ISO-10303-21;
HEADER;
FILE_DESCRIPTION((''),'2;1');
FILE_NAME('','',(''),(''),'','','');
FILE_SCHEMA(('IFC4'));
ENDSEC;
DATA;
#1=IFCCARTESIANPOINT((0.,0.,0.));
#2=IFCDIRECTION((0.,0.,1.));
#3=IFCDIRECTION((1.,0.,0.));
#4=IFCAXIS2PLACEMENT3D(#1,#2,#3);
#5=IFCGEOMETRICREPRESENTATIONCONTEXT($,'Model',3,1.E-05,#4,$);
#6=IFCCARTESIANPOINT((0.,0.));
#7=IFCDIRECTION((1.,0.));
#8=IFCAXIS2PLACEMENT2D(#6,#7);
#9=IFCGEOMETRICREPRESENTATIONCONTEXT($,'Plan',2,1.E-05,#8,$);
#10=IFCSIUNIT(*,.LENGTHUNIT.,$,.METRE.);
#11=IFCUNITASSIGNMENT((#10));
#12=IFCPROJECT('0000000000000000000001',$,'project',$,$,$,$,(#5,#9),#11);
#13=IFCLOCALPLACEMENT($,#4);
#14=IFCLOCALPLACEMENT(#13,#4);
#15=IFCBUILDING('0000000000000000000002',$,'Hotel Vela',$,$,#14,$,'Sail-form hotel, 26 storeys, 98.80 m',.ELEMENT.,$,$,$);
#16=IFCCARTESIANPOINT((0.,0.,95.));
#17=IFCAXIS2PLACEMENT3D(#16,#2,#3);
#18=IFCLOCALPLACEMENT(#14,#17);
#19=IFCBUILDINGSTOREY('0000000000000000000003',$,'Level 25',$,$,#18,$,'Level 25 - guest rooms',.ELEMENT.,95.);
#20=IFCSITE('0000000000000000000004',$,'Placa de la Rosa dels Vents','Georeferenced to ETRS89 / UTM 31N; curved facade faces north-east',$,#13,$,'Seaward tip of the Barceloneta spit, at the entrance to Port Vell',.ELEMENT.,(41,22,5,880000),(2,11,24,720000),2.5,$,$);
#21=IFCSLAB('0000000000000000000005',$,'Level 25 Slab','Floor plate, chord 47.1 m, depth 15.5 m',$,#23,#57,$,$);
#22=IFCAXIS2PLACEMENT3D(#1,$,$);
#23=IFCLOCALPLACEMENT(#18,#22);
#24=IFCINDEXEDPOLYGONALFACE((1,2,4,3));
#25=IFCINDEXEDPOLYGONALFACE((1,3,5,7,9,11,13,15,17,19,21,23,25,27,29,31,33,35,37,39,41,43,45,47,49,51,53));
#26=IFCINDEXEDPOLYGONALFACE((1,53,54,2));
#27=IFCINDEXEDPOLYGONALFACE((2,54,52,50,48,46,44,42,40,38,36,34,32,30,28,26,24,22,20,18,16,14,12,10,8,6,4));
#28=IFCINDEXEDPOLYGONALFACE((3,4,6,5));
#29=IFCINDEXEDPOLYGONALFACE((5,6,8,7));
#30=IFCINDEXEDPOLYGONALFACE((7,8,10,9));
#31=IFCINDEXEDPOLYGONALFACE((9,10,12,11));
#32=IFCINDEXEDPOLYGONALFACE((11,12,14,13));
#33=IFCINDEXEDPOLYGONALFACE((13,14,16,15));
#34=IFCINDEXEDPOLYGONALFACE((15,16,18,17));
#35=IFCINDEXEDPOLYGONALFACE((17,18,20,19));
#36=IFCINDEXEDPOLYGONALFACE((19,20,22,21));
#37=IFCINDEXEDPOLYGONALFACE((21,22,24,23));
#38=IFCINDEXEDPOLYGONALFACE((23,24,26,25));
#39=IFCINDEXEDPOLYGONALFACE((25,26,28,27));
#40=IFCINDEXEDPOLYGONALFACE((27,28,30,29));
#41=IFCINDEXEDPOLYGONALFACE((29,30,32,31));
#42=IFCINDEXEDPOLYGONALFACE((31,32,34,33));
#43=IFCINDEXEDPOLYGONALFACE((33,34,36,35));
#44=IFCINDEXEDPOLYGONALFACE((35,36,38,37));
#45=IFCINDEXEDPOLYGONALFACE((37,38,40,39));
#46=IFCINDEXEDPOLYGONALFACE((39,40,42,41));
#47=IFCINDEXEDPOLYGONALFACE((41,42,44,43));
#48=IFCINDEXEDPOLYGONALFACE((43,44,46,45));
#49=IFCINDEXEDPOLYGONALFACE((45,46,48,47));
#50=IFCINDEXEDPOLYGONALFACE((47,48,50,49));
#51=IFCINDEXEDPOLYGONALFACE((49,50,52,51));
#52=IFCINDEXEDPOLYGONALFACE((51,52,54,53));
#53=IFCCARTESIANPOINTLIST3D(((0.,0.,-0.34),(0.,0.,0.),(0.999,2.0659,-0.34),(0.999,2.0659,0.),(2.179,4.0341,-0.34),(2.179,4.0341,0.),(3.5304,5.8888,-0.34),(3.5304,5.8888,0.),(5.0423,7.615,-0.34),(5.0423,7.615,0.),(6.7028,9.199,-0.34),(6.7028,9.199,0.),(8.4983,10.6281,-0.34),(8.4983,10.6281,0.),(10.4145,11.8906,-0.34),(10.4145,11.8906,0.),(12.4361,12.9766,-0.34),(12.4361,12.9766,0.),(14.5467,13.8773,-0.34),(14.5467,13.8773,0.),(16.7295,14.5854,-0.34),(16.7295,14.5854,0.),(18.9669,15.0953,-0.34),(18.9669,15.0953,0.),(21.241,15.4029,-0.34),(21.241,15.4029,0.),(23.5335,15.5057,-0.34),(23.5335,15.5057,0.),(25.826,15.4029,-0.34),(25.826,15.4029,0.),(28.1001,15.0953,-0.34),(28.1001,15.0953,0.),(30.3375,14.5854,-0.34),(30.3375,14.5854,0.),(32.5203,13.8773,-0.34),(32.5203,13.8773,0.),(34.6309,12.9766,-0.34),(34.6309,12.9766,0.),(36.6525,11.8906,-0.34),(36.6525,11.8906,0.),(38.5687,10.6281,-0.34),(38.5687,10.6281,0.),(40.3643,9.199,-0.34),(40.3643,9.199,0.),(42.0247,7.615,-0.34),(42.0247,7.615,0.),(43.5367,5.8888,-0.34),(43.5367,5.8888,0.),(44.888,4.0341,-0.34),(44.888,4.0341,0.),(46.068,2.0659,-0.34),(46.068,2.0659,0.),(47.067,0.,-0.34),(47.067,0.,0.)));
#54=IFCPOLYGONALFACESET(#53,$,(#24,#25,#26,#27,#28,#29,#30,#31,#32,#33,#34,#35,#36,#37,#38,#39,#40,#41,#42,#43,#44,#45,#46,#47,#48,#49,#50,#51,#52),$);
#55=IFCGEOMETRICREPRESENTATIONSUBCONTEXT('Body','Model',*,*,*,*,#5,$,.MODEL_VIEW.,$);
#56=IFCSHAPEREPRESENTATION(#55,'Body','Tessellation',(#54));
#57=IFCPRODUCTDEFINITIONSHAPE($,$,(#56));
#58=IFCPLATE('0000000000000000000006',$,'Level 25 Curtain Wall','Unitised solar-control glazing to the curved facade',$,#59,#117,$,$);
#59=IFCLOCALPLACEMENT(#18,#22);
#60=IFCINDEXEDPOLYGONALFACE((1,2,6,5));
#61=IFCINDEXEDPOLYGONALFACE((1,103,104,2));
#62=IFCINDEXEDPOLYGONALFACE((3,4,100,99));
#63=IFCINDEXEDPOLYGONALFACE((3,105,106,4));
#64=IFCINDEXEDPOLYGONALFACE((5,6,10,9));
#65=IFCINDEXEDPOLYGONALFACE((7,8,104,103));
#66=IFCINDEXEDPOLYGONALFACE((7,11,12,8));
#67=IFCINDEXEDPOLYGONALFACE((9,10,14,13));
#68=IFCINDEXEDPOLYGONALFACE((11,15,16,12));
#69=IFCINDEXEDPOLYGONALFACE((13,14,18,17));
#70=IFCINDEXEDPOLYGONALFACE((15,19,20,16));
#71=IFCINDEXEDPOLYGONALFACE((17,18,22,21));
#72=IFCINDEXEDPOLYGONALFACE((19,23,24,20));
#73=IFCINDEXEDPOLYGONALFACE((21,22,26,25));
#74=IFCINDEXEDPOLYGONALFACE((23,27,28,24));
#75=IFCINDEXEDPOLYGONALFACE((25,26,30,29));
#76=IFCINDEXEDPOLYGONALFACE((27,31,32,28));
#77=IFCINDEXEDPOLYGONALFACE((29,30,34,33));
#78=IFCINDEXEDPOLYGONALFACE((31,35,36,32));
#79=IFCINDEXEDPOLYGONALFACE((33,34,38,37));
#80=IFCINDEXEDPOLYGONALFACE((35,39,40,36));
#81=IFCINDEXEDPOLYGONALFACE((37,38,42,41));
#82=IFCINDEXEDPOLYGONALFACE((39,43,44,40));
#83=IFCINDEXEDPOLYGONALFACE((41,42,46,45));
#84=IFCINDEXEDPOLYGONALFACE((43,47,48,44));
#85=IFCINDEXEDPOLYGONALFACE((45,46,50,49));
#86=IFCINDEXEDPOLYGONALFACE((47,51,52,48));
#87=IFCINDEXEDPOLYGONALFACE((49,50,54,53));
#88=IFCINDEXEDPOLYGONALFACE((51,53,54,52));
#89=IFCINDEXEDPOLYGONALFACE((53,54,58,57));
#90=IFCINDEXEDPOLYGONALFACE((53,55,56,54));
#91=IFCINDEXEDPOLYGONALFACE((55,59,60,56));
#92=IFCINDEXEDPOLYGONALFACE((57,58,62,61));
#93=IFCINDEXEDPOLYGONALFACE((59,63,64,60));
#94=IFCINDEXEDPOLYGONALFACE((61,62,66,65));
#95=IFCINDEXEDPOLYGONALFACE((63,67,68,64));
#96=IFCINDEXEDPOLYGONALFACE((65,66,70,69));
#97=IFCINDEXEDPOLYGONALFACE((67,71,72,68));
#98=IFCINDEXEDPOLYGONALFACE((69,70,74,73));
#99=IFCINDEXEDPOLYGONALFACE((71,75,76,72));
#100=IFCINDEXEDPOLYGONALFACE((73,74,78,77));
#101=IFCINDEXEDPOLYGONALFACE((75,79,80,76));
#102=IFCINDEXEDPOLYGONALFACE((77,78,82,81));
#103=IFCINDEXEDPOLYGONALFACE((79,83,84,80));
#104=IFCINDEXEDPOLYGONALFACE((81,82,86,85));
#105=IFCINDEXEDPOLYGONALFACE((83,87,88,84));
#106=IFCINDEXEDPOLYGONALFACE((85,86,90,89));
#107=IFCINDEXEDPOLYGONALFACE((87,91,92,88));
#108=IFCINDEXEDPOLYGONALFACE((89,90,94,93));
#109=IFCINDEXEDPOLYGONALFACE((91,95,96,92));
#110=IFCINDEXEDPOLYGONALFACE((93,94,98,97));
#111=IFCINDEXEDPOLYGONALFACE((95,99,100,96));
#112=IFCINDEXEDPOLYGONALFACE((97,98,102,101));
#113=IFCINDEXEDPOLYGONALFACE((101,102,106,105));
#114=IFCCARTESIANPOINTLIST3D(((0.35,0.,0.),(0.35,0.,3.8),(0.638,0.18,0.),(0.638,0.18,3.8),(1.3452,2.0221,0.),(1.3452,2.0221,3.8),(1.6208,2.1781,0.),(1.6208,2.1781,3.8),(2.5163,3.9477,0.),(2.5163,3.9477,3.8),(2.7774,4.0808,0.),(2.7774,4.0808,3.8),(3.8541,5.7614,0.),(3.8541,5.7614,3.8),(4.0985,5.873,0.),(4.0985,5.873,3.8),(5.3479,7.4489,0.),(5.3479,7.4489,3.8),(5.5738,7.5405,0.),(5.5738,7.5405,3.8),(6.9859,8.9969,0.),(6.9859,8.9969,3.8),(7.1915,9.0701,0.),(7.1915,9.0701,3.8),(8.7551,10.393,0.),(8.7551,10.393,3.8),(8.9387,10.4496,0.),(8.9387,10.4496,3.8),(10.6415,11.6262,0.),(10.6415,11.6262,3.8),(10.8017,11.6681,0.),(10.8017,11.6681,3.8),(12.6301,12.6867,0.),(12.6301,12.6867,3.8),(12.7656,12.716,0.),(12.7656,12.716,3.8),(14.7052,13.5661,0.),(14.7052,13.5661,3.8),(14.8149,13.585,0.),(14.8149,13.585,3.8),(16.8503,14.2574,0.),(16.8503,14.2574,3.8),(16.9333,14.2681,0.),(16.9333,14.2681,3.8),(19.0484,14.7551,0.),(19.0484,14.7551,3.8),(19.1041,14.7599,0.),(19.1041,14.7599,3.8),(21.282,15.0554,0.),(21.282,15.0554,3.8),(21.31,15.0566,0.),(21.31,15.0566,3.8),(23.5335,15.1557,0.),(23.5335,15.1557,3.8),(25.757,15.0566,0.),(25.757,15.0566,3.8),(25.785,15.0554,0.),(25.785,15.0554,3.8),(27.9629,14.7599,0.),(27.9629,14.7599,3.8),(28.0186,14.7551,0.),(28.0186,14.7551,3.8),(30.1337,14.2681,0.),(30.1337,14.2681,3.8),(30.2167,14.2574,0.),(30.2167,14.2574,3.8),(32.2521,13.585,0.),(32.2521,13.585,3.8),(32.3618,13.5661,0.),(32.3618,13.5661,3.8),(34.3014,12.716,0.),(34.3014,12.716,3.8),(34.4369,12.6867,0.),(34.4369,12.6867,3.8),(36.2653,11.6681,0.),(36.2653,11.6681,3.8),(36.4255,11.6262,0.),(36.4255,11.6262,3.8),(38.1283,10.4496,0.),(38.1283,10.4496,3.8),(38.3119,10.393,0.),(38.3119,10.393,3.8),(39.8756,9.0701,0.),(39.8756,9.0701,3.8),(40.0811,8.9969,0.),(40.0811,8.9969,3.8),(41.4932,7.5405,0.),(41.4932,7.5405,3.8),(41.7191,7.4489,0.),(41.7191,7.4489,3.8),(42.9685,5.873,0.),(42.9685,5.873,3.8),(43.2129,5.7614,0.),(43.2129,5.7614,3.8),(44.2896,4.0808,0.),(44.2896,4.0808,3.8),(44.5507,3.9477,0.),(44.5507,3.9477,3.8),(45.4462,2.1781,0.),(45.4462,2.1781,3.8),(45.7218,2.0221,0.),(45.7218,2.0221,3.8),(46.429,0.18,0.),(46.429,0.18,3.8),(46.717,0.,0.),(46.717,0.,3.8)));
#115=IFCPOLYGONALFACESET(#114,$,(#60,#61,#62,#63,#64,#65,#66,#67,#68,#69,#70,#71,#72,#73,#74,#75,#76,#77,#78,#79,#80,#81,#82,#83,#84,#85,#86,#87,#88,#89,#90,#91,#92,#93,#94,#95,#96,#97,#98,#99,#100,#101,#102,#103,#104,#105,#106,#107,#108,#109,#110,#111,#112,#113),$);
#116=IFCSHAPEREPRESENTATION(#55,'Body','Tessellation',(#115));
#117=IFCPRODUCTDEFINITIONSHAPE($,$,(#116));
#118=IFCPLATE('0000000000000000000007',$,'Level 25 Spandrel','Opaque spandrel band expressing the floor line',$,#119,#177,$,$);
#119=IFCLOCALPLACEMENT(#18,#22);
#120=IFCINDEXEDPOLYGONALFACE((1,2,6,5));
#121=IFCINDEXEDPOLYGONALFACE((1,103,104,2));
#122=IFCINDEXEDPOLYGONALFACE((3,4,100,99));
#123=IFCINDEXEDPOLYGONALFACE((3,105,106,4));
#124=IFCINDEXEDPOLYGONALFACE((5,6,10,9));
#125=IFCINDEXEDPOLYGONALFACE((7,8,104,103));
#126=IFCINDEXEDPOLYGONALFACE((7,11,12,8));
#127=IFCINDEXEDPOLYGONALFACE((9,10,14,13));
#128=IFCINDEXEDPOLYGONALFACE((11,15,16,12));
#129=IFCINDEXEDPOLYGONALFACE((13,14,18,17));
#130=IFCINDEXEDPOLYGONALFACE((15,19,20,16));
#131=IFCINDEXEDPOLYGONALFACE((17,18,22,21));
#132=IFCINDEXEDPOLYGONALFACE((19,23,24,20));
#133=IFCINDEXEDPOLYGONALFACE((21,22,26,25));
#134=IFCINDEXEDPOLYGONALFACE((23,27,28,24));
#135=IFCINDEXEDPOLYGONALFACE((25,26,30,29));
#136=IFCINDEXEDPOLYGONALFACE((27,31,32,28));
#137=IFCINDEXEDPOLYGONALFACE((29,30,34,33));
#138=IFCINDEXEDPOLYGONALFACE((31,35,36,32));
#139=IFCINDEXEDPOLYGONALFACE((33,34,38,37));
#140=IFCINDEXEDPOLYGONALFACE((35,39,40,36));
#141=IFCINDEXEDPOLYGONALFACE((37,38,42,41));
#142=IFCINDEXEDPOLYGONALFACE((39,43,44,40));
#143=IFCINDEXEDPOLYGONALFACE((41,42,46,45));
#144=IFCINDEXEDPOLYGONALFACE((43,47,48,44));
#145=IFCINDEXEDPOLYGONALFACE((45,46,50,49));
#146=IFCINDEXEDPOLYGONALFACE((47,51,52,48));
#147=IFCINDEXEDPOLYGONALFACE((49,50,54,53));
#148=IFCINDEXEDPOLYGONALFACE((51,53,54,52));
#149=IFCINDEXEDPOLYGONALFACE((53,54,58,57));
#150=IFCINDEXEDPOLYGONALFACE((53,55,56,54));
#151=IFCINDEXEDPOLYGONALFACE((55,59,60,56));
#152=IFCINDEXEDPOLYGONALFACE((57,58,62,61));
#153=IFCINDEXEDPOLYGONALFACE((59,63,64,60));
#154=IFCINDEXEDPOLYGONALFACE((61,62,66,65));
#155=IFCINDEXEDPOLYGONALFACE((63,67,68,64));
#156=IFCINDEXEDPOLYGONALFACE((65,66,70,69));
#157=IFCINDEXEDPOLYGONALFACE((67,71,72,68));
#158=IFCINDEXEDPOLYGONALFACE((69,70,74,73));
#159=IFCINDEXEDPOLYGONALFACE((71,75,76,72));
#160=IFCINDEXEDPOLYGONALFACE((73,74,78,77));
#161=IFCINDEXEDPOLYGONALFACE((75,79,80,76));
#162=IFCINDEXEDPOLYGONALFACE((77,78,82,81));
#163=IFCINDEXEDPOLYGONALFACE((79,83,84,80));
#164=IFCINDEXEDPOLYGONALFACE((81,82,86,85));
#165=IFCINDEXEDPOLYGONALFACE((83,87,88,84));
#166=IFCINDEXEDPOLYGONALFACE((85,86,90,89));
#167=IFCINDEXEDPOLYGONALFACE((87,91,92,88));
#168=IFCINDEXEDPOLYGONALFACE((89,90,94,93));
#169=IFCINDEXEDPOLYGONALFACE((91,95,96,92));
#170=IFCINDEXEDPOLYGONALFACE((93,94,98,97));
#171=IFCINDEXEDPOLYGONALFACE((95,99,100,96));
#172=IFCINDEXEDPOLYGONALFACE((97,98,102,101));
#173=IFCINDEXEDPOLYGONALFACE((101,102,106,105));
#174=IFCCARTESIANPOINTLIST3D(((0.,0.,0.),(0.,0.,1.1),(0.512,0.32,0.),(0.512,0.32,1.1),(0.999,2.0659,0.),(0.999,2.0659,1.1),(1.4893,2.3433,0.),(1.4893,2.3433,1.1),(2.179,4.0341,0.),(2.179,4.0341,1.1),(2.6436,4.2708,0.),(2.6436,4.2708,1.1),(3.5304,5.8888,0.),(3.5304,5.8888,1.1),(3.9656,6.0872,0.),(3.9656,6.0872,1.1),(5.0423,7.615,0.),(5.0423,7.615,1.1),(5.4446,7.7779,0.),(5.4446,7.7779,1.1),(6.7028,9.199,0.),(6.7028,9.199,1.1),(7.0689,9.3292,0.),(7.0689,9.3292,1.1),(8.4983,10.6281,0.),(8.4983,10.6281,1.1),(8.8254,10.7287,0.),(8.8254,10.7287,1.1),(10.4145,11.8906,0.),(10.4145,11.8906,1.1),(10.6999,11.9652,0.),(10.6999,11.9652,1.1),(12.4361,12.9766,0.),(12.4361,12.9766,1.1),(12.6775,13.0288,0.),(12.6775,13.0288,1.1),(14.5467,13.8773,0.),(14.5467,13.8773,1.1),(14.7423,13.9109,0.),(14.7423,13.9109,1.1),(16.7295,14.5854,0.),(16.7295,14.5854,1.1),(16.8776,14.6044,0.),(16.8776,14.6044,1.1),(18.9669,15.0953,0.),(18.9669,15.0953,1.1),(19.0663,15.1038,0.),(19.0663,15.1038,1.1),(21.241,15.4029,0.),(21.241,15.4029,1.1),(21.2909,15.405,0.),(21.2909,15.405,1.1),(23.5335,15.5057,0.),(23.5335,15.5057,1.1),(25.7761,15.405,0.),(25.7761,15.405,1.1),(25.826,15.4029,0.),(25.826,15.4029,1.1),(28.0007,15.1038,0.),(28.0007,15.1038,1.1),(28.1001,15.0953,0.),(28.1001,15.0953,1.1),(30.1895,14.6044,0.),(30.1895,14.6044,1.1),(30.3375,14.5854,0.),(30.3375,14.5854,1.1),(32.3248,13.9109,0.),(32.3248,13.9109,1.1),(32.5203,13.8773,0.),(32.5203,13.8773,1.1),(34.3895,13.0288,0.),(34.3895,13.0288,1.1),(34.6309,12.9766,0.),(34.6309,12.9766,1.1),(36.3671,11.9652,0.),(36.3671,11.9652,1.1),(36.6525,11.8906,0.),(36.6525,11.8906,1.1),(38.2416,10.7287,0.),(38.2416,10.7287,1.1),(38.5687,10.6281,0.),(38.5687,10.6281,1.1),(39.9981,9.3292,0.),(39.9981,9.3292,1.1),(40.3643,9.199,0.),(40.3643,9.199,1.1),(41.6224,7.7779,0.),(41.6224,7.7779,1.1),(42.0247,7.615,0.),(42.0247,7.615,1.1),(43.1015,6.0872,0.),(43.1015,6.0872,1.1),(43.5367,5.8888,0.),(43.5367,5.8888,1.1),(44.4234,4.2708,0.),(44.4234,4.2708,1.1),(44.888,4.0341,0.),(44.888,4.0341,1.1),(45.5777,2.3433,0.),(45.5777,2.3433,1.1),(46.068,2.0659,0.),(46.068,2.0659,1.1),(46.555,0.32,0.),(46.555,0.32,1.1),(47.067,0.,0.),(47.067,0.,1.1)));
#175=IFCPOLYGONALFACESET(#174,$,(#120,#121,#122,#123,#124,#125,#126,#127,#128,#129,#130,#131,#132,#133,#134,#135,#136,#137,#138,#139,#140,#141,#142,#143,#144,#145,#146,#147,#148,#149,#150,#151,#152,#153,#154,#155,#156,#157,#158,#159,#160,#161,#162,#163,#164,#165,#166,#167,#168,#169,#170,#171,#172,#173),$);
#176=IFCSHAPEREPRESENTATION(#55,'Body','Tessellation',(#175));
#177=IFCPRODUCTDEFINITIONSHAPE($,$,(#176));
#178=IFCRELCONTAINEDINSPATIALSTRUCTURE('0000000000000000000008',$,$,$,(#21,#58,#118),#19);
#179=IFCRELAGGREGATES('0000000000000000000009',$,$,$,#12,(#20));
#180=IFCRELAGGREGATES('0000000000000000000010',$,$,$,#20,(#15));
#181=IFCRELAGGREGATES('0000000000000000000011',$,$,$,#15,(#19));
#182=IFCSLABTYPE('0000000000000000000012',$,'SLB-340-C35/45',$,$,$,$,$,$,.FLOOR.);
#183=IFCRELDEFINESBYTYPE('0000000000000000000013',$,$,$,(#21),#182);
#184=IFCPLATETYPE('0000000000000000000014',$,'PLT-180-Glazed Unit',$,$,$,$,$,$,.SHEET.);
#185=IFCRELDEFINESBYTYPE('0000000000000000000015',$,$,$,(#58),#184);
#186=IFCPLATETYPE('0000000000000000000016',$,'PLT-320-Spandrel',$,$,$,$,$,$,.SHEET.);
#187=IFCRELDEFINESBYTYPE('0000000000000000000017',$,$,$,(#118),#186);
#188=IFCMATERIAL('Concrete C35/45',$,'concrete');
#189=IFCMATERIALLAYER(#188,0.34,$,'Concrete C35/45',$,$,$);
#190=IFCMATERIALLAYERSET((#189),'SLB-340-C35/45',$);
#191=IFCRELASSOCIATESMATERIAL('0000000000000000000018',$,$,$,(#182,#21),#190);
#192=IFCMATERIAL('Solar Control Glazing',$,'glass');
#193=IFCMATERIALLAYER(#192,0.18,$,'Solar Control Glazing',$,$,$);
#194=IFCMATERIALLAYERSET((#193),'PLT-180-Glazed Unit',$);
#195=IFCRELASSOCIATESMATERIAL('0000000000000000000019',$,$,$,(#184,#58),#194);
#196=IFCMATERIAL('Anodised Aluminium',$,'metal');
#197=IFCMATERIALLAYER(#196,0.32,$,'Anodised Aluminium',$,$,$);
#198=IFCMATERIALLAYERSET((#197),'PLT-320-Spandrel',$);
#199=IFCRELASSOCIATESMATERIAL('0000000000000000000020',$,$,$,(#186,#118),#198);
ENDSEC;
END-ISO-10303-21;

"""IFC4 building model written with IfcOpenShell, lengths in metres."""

from ifc_helpers import new_model, si_unit, frame, origin_with_axes, origin_2d_with_axis, place, context, subcontext, project, spatial, line, indexed_curve, outline, extrude, material, layer, layer_set, layer_usage, type_object, element, save


model = new_model("IFC4")

# Units and contexts
model_context = context("Model", 3, precision=1e-05, world=origin_with_axes())
plan_context = context("Plan", 2, precision=1e-05, world=origin_2d_with_axis())
body_context = subcontext(model_context, "Body", "Model", "MODEL_VIEW")
ifc_project = project(units=[si_unit("LENGTHUNIT", "METRE")], contexts=[model_context, plan_context])

# Site, building, storey
site_placement = place(None, origin_with_axes())
site = spatial("IfcSite", under=ifc_project, at=site_placement, Name="Placa de la Rosa dels Vents", Description="Georeferenced to ETRS89 / UTM 31N; curved facade faces north-east", LongName="Seaward tip of the Barceloneta spit, at the entrance to Port Vell", CompositionType="ELEMENT", RefLatitude=(41, 22, 5, 880000), RefLongitude=(2, 11, 24, 720000), RefElevation=2.5)
building_placement = place(site_placement, origin_with_axes())
building = spatial("IfcBuilding", under=site, at=building_placement, Name="Hotel Vela", LongName="Sail-form hotel, 26 storeys, 98.80 m", CompositionType="ELEMENT")
storey_placement = place(building_placement, frame((0.0, 0.0, 95.0), z_axis=(0.0, 0.0, 1.0), x_axis=(1.0, 0.0, 0.0)))
storey = spatial("IfcBuildingStorey", under=building, at=storey_placement, Name="Level 25", LongName="Level 25 - guest rooms", CompositionType="ELEMENT", Elevation=95.0)

# Slab
ifc_material_1 = material(Name="Concrete C35/45", Category="concrete")
ifc_layer_1 = layer(ifc_material_1, 0.34, Name="Concrete C35/45")
ifc_layer_set_1 = layer_set([ifc_layer_1], Name="SLB-340-C35/45")
ifc_layer_usage_1 = layer_usage(ifc_layer_set_1, "AXIS3", "POSITIVE", 0.0)
slab_type = type_object("IfcSlabType", Name="SLB-340-C35/45", PredefinedType="FLOOR", material=ifc_layer_set_1)
slab_placement = place(storey_placement, frame((0.0, 0.0, -0.34), z_axis=(0.0, 0.0, 1.0), x_axis=(1.0, 0.0, 0.0)))
element("IfcSlab", 1, at=slab_placement, inside=storey, type_object=slab_type, material=ifc_layer_usage_1, Name="Level 25 Slab", Description="Floor plate, chord 47.1 m, depth 15.5 m", context=body_context, shape_type="SweptSolid", body=[
    extrude(outline(indexed_curve([(0.0, 0.0), (47.067, 0.0), (46.068, 2.0659), (44.888, 4.0341), (43.5367, 5.8888), (42.0247, 7.615), (40.3643, 9.199), (38.5687, 10.6281), (36.6525, 11.8906), (34.6309, 12.9766), (32.5203, 13.8773), (30.3375, 14.5854), (28.1001, 15.0953), (25.826, 15.4029), (23.5335, 15.5057), (21.241, 15.4029), (18.9669, 15.0953), (16.7295, 14.5854), (14.5467, 13.8773), (12.4361, 12.9766), (10.4145, 11.8906), (8.4983, 10.6281), (6.7028, 9.199), (5.0423, 7.615), (3.5304, 5.8888), (2.179, 4.0341), (0.999, 2.0659)], segments=[line(1, 2, 3, 4, 5, 6, 7, 8, 9, 10, 11, 12, 13, 14, 15, 16, 17, 18, 19, 20, 21, 22, 23, 24, 25, 26, 27, 1)])), origin_with_axes(), (0.0, 0.0, 1.0), 0.34),
])

# Plates
ifc_material_2 = material(Name="Solar Control Glazing", Category="glass")
ifc_layer_2 = layer(ifc_material_2, 0.18, Name="Solar Control Glazing")
ifc_layer_set_2 = layer_set([ifc_layer_2], Name="PLT-180-Glazed Unit")
ifc_layer_usage_2 = layer_usage(ifc_layer_set_2, "AXIS2", "POSITIVE", 0.0)
plate_type_1 = type_object("IfcPlateType", Name="PLT-180-Glazed Unit", PredefinedType="SHEET", material=ifc_layer_set_2)
plate_1_placement = place(storey_placement, frame((0.35, 0.0, 0.0), z_axis=(0.0, 0.0, 1.0), x_axis=(1.0, 0.0, 0.0)))
element("IfcPlate", 2, at=plate_1_placement, inside=storey, type_object=plate_type_1, material=ifc_layer_usage_2, Name="Level 25 Curtain Wall", Description="Unitised solar-control glazing to the curved facade", context=body_context, shape_type="SweptSolid", body=[
    extrude(outline(indexed_curve([(46.367, 0.0), (45.3718, 2.0221), (44.2007, 3.9477), (42.8629, 5.7614), (41.3691, 7.4489), (39.7311, 8.9969), (37.9619, 10.393), (36.0755, 11.6262), (34.0869, 12.6867), (32.0118, 13.5661), (29.8667, 14.2574), (27.6686, 14.7551), (25.435, 15.0554), (23.1835, 15.1557), (20.932, 15.0554), (18.6984, 14.7551), (16.5003, 14.2574), (14.3552, 13.5661), (12.2801, 12.6867), (10.2915, 11.6262), (8.4051, 10.393), (6.6359, 8.9969), (4.9979, 7.4489), (3.5041, 5.7614), (2.1663, 3.9477), (0.9952, 2.0221), (0.0, 0.0), (46.079, 0.18), (1.2708, 2.1781), (2.4274, 4.0808), (3.7485, 5.873), (5.2238, 7.5405), (6.8415, 9.0701), (8.5887, 10.4496), (10.4517, 11.6681), (12.4156, 12.716), (14.4649, 13.585), (16.5833, 14.2681), (18.7541, 14.7599), (20.96, 15.0566), (23.1835, 15.1557), (25.407, 15.0566), (27.6129, 14.7599), (29.7837, 14.2681), (31.9021, 13.585), (33.9514, 12.716), (35.9153, 11.6681), (37.7783, 10.4496), (39.5256, 9.0701), (41.1432, 7.5405), (42.6185, 5.873), (43.9396, 4.0808), (45.0962, 2.1781), (0.288, 0.18)], segments=[line(1, 2, 3, 4, 5, 6, 7, 8, 9, 10, 11, 12, 13, 14, 15, 16, 17, 18, 19, 20, 21, 22, 23, 24, 25, 26, 27, 28, 29, 30, 31, 32, 33, 34, 35, 36, 37, 38, 39, 40, 41, 42, 43, 44, 45, 46, 47, 48, 49, 50, 51, 52, 53, 54, 1)])), origin_with_axes(), (0.0, 0.0, 1.0), 3.8),
])
ifc_material_3 = material(Name="Anodised Aluminium", Category="metal")
ifc_layer_3 = layer(ifc_material_3, 0.32, Name="Anodised Aluminium")
ifc_layer_set_3 = layer_set([ifc_layer_3], Name="PLT-320-Spandrel")
ifc_layer_usage_3 = layer_usage(ifc_layer_set_3, "AXIS2", "POSITIVE", 0.0)
plate_type_2 = type_object("IfcPlateType", Name="PLT-320-Spandrel", PredefinedType="SHEET", material=ifc_layer_set_3)
plate_2_placement = place(storey_placement, origin_with_axes())
element("IfcPlate", 3, at=plate_2_placement, inside=storey, type_object=plate_type_2, material=ifc_layer_usage_3, Name="Level 25 Spandrel", Description="Opaque spandrel band expressing the floor line", context=body_context, shape_type="SweptSolid", body=[
    extrude(outline(indexed_curve([(47.067, 0.0), (46.068, 2.0659), (44.888, 4.0341), (43.5367, 5.8888), (42.0247, 7.615), (40.3643, 9.199), (38.5687, 10.6281), (36.6525, 11.8906), (34.6309, 12.9766), (32.5203, 13.8773), (30.3375, 14.5854), (28.1001, 15.0953), (25.826, 15.4029), (23.5335, 15.5057), (21.241, 15.4029), (18.9669, 15.0953), (16.7295, 14.5854), (14.5467, 13.8773), (12.4361, 12.9766), (10.4145, 11.8906), (8.4983, 10.6281), (6.7028, 9.199), (5.0423, 7.615), (3.5304, 5.8888), (2.179, 4.0341), (0.999, 2.0659), (0.0, 0.0), (46.555, 0.32), (1.4893, 2.3433), (2.6436, 4.2708), (3.9656, 6.0872), (5.4446, 7.7779), (7.0689, 9.3292), (8.8254, 10.7287), (10.6999, 11.9652), (12.6775, 13.0288), (14.7423, 13.9109), (16.8776, 14.6044), (19.0663, 15.1038), (21.2909, 15.405), (23.5335, 15.5057), (25.7761, 15.405), (28.0007, 15.1038), (30.1895, 14.6044), (32.3248, 13.9109), (34.3895, 13.0288), (36.3671, 11.9652), (38.2416, 10.7287), (39.9981, 9.3292), (41.6224, 7.7779), (43.1015, 6.0872), (44.4234, 4.2708), (45.5777, 2.3433), (0.512, 0.32)], segments=[line(1, 2, 3, 4, 5, 6, 7, 8, 9, 10, 11, 12, 13, 14, 15, 16, 17, 18, 19, 20, 21, 22, 23, 24, 25, 26, 27, 28, 29, 30, 31, 32, 33, 34, 35, 36, 37, 38, 39, 40, 41, 42, 43, 44, 45, 46, 47, 48, 49, 50, 51, 52, 53, 54, 1)])), origin_with_axes(), (0.0, 0.0, 1.0), 1.1),
])

save(model, "model.ifc")
